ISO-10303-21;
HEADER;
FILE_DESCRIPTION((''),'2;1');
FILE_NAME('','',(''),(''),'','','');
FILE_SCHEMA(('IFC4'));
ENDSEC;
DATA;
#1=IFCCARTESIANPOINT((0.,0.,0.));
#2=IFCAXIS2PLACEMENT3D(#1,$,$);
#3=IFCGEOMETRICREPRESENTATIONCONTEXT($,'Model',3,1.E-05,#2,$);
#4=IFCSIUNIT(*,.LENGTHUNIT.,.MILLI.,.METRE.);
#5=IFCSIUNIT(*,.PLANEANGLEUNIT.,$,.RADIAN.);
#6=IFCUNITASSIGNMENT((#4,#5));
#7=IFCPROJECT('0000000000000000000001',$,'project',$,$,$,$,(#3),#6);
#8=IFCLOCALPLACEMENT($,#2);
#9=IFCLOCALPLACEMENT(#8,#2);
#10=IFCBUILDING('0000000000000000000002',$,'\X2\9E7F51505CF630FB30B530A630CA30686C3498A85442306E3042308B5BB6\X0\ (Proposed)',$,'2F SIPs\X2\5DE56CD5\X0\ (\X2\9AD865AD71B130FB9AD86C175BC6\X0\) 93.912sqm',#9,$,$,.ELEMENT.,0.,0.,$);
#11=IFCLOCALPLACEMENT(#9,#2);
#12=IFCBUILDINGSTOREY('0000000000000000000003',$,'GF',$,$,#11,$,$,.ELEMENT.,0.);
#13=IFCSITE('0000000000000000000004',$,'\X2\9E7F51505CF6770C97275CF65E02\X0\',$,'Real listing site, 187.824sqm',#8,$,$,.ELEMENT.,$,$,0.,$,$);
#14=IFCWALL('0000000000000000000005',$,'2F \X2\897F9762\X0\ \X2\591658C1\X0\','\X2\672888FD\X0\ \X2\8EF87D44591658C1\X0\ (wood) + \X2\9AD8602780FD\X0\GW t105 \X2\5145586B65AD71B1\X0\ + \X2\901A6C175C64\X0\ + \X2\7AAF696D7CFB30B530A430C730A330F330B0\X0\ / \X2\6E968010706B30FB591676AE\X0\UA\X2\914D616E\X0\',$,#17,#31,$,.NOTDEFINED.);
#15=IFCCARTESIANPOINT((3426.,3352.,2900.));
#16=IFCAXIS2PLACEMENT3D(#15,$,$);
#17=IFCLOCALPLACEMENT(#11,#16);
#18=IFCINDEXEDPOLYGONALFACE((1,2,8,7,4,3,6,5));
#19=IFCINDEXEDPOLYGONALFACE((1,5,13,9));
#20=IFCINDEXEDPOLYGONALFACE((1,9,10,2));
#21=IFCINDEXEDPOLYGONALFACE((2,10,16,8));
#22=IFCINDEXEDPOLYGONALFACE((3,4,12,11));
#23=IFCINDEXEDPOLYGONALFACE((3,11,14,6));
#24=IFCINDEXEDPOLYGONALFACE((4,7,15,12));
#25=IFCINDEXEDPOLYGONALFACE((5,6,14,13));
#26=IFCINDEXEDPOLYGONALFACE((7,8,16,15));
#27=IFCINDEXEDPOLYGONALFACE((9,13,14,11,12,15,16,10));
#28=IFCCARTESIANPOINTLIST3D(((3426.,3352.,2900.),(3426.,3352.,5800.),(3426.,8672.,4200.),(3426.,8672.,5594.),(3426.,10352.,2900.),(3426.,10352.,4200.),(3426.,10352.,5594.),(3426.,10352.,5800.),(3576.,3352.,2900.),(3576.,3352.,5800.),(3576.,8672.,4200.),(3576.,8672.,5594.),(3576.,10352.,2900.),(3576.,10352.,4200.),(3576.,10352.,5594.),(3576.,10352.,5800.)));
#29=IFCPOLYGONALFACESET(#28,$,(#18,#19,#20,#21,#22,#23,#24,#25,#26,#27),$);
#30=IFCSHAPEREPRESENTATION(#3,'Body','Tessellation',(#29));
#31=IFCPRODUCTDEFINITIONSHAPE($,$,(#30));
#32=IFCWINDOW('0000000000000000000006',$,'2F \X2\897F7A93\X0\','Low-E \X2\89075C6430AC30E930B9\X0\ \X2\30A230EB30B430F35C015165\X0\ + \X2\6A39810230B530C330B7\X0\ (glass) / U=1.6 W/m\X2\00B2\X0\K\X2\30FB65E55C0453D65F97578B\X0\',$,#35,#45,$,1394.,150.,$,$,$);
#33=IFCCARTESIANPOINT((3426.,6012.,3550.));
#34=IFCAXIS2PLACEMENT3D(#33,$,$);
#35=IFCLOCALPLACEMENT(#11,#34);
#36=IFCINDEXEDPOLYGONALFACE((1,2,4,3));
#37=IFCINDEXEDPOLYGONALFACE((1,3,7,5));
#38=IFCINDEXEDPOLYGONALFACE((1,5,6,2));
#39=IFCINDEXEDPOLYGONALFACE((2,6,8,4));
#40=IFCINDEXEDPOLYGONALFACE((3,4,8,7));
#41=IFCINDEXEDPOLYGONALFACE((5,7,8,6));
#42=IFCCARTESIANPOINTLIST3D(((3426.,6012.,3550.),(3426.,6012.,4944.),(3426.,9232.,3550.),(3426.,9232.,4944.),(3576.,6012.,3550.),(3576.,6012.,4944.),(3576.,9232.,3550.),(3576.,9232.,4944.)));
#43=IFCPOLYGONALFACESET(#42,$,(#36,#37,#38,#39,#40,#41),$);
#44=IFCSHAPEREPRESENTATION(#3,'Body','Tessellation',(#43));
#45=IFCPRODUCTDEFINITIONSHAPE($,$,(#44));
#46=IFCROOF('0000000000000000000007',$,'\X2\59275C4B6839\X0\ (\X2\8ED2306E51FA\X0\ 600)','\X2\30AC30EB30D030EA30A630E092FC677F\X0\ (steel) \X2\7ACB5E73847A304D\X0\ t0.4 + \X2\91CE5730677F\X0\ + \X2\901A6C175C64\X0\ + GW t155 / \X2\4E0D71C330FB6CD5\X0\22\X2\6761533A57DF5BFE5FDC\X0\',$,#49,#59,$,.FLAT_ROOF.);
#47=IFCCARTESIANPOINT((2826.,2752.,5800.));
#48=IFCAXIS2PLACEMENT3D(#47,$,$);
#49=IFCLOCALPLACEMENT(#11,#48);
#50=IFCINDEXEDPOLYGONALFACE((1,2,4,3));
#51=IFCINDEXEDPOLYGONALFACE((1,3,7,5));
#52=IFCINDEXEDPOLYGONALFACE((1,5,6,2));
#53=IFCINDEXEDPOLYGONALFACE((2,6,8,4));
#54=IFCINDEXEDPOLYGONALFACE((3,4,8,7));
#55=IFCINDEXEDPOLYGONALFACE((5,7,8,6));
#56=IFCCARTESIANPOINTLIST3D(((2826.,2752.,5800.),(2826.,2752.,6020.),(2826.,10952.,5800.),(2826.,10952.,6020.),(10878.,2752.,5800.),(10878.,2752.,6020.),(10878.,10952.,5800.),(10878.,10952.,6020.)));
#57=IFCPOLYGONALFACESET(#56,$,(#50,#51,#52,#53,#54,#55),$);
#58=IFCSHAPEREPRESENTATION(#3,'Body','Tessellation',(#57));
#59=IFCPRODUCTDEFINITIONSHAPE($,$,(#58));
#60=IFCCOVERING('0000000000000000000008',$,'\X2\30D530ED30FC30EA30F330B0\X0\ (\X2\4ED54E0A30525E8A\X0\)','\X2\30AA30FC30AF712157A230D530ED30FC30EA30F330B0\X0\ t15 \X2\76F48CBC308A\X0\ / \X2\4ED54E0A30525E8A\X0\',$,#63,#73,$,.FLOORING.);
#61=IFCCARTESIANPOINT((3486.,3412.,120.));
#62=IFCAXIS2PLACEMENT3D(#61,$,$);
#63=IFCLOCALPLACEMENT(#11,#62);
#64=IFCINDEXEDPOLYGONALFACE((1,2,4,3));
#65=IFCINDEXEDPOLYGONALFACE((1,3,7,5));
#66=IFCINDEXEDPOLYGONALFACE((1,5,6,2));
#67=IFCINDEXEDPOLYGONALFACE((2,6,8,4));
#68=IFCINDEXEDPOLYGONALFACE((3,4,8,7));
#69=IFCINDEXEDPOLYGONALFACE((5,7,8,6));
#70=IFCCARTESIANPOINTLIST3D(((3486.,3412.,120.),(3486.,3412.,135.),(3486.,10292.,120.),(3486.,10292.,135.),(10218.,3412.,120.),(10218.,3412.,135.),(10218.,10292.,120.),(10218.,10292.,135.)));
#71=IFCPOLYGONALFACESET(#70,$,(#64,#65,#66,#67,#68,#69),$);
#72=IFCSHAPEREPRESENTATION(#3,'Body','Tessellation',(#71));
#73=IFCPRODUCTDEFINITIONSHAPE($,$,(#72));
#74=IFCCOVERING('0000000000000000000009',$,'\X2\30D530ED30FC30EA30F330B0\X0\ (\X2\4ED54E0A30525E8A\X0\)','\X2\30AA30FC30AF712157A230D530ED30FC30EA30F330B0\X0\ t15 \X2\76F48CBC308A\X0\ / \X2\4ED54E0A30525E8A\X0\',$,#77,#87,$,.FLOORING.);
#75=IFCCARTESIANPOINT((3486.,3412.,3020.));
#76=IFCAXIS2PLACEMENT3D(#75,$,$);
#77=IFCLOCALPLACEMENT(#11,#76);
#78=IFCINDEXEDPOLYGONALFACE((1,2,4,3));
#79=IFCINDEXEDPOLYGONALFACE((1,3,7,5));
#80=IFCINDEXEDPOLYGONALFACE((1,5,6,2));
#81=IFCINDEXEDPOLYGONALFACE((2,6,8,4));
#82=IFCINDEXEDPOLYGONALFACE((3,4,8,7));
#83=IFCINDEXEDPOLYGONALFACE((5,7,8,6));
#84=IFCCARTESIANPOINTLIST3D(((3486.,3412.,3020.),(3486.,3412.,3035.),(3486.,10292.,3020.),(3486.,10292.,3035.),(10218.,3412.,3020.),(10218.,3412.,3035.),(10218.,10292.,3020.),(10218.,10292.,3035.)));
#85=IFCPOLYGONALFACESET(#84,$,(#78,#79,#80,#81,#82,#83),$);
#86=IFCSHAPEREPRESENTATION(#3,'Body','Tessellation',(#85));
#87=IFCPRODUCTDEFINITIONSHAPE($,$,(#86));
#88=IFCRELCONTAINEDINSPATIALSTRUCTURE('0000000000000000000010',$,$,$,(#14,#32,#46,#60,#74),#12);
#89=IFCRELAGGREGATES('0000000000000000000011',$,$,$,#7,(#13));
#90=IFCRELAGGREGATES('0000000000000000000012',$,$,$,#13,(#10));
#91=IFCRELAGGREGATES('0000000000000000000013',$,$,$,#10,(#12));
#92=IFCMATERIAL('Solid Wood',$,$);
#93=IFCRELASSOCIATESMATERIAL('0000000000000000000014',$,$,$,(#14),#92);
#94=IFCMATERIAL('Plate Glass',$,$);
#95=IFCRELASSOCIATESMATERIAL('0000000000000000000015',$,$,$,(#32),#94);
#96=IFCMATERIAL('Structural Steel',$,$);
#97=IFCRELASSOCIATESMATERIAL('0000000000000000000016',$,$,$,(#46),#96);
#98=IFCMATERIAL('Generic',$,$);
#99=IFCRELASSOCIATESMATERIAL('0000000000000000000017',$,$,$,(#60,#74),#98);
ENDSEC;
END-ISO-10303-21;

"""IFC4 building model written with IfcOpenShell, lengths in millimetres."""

from ifc_helpers import new_model, si_unit, frame, frame_2d, origin, place, context, project, spatial, rectangle, extrude, material, element, fill, save


model = new_model("IFC4")

# Units and contexts
model_context = context("Model", 3, precision=1e-05, world=origin())
ifc_project = project(units=[si_unit("LENGTHUNIT", "METRE", prefix="MILLI"), si_unit("PLANEANGLEUNIT", "RADIAN")], contexts=[model_context])

# Site, building, storey
site_placement = place(None, origin())
site = spatial("IfcSite", under=ifc_project, at=site_placement, Name="鹿児島県霧島市", ObjectType="Real listing site, 187.824sqm", CompositionType="ELEMENT", RefElevation=0.0)
building_placement = place(site_placement, origin())
building = spatial("IfcBuilding", under=site, at=building_placement, Name="鹿児島・サウナと水風呂のある家 (Proposed)", ObjectType="2F SIPs工法 (高断熱・高気密) 93.912sqm", CompositionType="ELEMENT", ElevationOfRefHeight=0.0, ElevationOfTerrain=0.0)
storey_placement = place(building_placement, origin())
storey = spatial("IfcBuildingStorey", under=building, at=storey_placement, Name="GF", CompositionType="ELEMENT", Elevation=0.0)

# Shared definitions
ifc_material_1 = material(Name="Solid Wood")

# Shared definitions
ifc_material_2 = material(Name="Plate Glass")

# Wall, opening, window
wall_1_placement = place(storey_placement, frame((3426.0, 3352.0, 2900.0)))
wall_1 = element("IfcWall", 1, at=wall_1_placement, inside=storey, material=ifc_material_1, Name="2F 西面 外壁", Description="木製 軸組外壁 (wood) + 高性能GW t105 充填断熱 + 通気層 + 窯業系サイディング / 準耐火・外皮UA配慮", PredefinedType="NOTDEFINED", context=model_context, shape_type="SweptSolid", body=[
    extrude(rectangle(XDim=150.0, YDim=7000.0, at=frame_2d((75.0, 3500.0))), frame((3426.0, 3352.0, 2900.0)), (0.0, 0.0, 1.0), 2900.0),
])
opening_1_placement = place(storey_placement, frame((3426.0, 6012.0, 3550.0)))
opening_1 = element("IfcOpeningElement", 2, at=opening_1_placement, cuts=wall_1, PredefinedType="NOTDEFINED", context=model_context, shape_type="SweptSolid", body=[
    extrude(rectangle(XDim=150.0, YDim=3220.0, at=frame_2d((75.0, 1610.0))), frame((3426.0, 6012.0, 3550.0)), (0.0, 0.0, 1.0), 1394.0),
])
window_1_placement = place(storey_placement, frame((3426.0, 6012.0, 3550.0)))
window_1 = element("IfcWindow", 3, at=window_1_placement, inside=storey, material=ifc_material_2, Name="2F 西窓", Description="Low-E 複層ガラス アルゴン封入 + 樹脂サッシ (glass) / U=1.6 W/m²K・日射取得型", OverallHeight=1394.0, OverallWidth=150.0, context=model_context, shape_type="SweptSolid", body=[
    extrude(rectangle(XDim=150.0, YDim=3220.0, at=frame_2d((75.0, 1610.0))), frame((3426.0, 6012.0, 3550.0)), (0.0, 0.0, 1.0), 1394.0),
])
fill(opening_1, window_1)

# Roof
ifc_material_3 = material(Name="Structural Steel")
roof_placement = place(storey_placement, frame((2826.0, 2752.0, 5800.0)))
element("IfcRoof", 4, at=roof_placement, inside=storey, material=ifc_material_3, Name="大屋根 (軒の出 600)", Description="ガルバリウム鋼板 (steel) 立平葺き t0.4 + 野地板 + 通気層 + GW t155 / 不燃・法22条区域対応", PredefinedType="FLAT_ROOF", context=model_context, shape_type="SweptSolid", body=[
    extrude(rectangle(XDim=8052.0, YDim=8200.0, at=frame_2d((4026.0, 4100.0))), frame((2826.0, 2752.0, 5800.0)), (0.0, 0.0, 1.0), 220.0),
])

# Coverings
ifc_material_4 = material(Name="Generic")
covering_1_placement = place(storey_placement, frame((3486.0, 3412.0, 120.0)))
element("IfcCovering", 5, at=covering_1_placement, inside=storey, material=ifc_material_4, Name="フローリング (仕上げ床)", Description="オーク無垢フローリング t15 直貼り / 仕上げ床", PredefinedType="FLOORING", context=model_context, shape_type="SweptSolid", body=[
    extrude(rectangle(XDim=6732.0, YDim=6880.0, at=frame_2d((3366.0, 3440.0))), frame((3486.0, 3412.0, 120.0)), (0.0, 0.0, 1.0), 15.0),
])
covering_2_placement = place(storey_placement, frame((3486.0, 3412.0, 3020.0)))
element("IfcCovering", 6, at=covering_2_placement, inside=storey, material=ifc_material_4, Name="フローリング (仕上げ床)", Description="オーク無垢フローリング t15 直貼り / 仕上げ床", PredefinedType="FLOORING", context=model_context, shape_type="SweptSolid", body=[
    extrude(rectangle(XDim=6732.0, YDim=6880.0, at=frame_2d((3366.0, 3440.0))), frame((3486.0, 3412.0, 3020.0)), (0.0, 0.0, 1.0), 15.0),
])

save(model, "model.ifc")
